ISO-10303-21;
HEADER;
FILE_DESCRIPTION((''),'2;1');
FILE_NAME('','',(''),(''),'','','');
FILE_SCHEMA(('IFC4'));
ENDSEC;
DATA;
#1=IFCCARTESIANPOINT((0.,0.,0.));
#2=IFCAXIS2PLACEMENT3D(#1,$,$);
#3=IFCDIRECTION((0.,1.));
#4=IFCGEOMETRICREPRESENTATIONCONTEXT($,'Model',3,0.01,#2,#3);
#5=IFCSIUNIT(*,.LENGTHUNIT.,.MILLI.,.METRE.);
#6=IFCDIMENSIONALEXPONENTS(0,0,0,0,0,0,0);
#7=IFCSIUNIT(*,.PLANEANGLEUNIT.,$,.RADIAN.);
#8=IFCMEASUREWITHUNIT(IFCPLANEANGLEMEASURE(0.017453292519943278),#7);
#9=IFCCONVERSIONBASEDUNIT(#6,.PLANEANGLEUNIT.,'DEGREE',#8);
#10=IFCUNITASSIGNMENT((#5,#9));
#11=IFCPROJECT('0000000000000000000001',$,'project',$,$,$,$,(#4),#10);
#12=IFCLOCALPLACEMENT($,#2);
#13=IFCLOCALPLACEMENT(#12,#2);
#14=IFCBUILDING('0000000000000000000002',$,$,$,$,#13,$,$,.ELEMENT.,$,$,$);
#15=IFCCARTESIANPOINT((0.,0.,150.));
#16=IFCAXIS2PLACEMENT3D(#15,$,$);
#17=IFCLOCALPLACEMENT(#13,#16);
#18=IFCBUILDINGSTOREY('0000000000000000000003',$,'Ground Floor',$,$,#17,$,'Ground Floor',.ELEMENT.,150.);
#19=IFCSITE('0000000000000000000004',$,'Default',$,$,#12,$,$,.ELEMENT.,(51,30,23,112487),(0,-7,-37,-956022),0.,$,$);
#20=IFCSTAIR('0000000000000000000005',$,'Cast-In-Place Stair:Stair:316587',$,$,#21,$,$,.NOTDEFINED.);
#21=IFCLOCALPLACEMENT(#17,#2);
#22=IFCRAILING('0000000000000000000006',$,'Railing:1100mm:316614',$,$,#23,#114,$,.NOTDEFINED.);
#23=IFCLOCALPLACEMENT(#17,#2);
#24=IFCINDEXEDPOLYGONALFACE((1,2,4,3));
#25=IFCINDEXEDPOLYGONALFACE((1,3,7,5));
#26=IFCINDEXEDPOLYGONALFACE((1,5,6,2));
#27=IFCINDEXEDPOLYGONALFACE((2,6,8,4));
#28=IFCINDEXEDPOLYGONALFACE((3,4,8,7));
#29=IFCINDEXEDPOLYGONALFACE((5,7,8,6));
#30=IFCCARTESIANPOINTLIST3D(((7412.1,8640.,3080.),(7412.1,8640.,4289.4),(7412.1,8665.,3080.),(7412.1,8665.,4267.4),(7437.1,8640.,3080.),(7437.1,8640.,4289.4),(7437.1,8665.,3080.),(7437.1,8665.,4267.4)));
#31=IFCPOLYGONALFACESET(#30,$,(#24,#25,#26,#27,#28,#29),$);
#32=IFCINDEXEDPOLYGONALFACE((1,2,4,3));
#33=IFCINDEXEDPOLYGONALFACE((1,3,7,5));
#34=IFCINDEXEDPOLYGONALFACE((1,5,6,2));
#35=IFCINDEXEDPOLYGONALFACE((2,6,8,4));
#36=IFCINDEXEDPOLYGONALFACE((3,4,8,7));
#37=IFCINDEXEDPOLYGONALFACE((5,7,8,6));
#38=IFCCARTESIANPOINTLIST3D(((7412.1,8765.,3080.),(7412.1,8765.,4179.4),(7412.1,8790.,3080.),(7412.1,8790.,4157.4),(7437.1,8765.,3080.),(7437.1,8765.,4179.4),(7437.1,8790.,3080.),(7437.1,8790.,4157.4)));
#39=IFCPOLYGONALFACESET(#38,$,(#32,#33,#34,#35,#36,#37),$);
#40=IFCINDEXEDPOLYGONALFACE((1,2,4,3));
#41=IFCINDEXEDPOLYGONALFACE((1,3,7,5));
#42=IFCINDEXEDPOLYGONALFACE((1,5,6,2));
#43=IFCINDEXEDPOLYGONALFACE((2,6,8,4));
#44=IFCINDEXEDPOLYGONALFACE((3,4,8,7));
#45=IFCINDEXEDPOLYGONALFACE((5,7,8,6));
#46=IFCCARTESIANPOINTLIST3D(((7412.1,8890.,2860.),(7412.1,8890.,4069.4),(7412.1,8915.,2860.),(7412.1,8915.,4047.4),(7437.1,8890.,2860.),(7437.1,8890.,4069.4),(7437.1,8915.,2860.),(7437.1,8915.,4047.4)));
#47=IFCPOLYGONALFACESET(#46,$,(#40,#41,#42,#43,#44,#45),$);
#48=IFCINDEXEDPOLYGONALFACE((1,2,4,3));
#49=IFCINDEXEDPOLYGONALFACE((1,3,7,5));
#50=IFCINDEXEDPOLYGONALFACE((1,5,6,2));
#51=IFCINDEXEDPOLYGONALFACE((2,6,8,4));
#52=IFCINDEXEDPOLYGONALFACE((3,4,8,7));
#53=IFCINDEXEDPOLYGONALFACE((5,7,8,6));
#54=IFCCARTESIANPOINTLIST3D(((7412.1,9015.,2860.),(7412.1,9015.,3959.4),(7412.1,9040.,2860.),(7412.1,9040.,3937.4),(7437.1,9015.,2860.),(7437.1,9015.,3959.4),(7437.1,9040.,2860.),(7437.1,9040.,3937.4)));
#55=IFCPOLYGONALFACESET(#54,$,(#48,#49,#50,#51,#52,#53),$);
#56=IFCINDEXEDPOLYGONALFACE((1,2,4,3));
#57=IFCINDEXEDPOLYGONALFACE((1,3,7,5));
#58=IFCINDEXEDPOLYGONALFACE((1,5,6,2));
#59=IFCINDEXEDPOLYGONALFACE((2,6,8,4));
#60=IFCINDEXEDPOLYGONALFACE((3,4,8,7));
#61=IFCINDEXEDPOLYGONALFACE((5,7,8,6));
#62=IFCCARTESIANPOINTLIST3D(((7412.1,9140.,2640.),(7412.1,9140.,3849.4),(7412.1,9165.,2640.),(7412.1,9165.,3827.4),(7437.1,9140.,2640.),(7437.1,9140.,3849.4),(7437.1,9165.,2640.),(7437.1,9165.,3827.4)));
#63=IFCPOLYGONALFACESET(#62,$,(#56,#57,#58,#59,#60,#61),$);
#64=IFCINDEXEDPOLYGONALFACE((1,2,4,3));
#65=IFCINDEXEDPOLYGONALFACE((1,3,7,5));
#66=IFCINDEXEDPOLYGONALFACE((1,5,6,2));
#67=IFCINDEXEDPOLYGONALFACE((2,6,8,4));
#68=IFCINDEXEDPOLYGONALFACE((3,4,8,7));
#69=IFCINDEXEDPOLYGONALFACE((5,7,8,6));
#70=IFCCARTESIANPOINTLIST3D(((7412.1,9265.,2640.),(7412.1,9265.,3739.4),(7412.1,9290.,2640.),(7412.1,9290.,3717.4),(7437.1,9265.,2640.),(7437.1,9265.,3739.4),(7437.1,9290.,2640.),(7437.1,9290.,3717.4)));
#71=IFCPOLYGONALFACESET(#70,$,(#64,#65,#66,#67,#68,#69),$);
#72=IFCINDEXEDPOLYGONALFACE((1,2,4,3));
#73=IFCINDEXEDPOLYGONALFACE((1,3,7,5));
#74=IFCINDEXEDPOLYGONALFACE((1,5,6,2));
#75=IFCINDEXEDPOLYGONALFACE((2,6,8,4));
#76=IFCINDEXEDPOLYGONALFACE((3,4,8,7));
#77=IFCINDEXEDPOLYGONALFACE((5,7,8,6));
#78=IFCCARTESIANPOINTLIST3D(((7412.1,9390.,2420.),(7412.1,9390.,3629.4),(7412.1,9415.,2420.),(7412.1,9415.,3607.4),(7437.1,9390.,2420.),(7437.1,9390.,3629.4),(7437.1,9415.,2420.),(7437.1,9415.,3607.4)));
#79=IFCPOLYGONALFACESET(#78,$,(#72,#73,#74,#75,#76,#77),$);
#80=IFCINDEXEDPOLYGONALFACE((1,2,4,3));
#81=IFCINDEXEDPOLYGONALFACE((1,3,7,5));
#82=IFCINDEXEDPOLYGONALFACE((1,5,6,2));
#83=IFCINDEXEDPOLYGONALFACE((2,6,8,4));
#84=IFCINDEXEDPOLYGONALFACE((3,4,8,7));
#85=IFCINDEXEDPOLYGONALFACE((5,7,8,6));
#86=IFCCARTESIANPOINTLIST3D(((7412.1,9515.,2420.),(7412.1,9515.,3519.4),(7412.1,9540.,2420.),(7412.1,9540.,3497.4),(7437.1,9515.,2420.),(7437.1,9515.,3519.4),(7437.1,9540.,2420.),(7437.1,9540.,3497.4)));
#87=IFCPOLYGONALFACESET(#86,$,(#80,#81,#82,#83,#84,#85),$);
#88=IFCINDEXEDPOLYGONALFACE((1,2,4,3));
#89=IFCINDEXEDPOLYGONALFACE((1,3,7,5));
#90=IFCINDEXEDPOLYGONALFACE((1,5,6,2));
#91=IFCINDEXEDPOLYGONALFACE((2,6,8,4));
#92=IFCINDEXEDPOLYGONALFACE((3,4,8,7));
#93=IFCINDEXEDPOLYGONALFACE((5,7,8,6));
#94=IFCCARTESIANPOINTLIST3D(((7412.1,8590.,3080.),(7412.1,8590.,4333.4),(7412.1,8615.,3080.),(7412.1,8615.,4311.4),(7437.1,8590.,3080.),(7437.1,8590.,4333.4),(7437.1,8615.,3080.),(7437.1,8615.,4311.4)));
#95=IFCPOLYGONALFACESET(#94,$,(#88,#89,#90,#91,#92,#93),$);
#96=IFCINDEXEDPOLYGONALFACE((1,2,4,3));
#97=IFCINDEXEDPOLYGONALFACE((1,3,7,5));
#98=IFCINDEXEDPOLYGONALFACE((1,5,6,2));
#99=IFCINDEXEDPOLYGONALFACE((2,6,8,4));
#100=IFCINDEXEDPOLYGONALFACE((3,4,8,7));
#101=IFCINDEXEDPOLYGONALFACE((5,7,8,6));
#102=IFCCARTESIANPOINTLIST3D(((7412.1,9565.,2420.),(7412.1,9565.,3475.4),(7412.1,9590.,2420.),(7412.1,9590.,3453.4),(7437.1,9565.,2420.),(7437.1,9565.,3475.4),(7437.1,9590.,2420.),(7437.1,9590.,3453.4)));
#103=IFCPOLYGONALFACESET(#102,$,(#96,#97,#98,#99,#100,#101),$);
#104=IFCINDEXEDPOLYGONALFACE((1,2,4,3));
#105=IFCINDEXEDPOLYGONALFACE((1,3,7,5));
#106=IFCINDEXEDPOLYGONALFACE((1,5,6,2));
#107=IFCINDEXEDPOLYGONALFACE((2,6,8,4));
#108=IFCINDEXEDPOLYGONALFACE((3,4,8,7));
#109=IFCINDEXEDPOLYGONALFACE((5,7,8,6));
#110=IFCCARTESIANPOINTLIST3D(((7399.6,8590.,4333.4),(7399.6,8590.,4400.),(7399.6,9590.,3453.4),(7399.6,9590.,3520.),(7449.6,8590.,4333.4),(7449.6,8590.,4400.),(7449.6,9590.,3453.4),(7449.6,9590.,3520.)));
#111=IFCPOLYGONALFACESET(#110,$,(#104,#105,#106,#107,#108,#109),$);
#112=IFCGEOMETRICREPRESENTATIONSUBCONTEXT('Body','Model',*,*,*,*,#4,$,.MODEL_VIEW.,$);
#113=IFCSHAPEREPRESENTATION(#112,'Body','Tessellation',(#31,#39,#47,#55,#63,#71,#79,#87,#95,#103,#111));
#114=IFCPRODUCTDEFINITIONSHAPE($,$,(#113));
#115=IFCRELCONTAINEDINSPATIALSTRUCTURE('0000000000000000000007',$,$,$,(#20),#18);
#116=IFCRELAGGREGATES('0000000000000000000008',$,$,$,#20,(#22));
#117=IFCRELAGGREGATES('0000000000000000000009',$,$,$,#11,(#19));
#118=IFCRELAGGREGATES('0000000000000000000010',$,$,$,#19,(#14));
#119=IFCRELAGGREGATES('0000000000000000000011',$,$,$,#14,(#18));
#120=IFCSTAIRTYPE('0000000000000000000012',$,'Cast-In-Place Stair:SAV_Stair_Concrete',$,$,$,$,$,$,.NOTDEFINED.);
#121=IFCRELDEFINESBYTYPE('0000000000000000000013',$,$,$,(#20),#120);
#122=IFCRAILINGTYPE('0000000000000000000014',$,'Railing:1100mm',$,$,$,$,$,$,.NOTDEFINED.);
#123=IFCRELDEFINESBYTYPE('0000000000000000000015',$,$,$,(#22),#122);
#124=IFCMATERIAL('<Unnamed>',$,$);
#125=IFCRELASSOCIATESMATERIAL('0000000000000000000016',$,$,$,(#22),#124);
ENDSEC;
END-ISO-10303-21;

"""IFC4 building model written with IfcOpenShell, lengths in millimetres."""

from ifc_helpers import new_model, entity, si_unit, converted_unit, direction, frame, origin, place, context, subcontext, project, spatial, polyline, outline, extrude, material, type_object, element, aggregate, save


model = new_model("IFC4")

# Units and contexts
model_context = context("Model", 3, precision=0.01, world=origin(), true_north=direction((0.0, 1.0)))
body_context = subcontext(model_context, "Body", "Model", "MODEL_VIEW")
ifc_project = project(units=[si_unit("LENGTHUNIT", "METRE", prefix="MILLI"), converted_unit("PLANEANGLEUNIT", "DEGREE", entity("IfcPlaneAngleMeasure", 0.017453292519943278), si_unit("PLANEANGLEUNIT", "RADIAN"), dimensions=[0, 0, 0, 0, 0, 0, 0])], contexts=[model_context])

# Site, building, storey
site_placement = place(None, origin())
site = spatial("IfcSite", under=ifc_project, at=site_placement, Name="Default", CompositionType="ELEMENT", RefLatitude=(51, 30, 23, 112487), RefLongitude=(0, -7, -37, -956022), RefElevation=0.0)
building_placement = place(site_placement, origin())
building = spatial("IfcBuilding", under=site, at=building_placement, CompositionType="ELEMENT")
storey_placement = place(building_placement, frame((0.0, 0.0, 150.0)))
storey = spatial("IfcBuildingStorey", under=building, at=storey_placement, Name="Ground Floor", LongName="Ground Floor", CompositionType="ELEMENT", Elevation=150.0)

# Shared definitions
ifc_material_1 = material(Name="<Unnamed>")

# Stair, railing
stair_type = type_object("IfcStairType", Name="Cast-In-Place Stair:SAV_Stair_Concrete", PredefinedType="NOTDEFINED")
stair_placement = place(storey_placement, origin())
stair = element("IfcStair", 1, at=stair_placement, inside=storey, type_object=stair_type, Name="Cast-In-Place Stair:Stair:316587", PredefinedType="NOTDEFINED")
railing_type_1 = type_object("IfcRailingType", Name="Railing:1100mm", PredefinedType="NOTDEFINED")
railing_1_placement = place(stair_placement, frame((7399.6, 8590.0, 2420.0)))
railing_1 = element("IfcRailing", 2, at=railing_1_placement, type_object=railing_type_1, material=ifc_material_1, Name="Railing:1100mm:316614", PredefinedType="NOTDEFINED", context=body_context, shape_type="SweptSolid", body=[
    extrude(outline(polyline([(-599.2, -12.5), (588.2, -12.5), (610.2, 12.5), (-599.2, 12.5), (-599.2, -12.5)])), frame((12.5, 62.5, 1259.2), z_axis=(1.0, 0.0, 0.0), x_axis=(0.0, 0.0, 1.0)), (0.0, 0.0, 1.0), 25.0),
    extrude(outline(polyline([(-544.2, -12.5), (533.2, -12.5), (555.2, 12.5), (-544.2, 12.5), (-544.2, -12.5)])), frame((12.5, 187.5, 1204.2), z_axis=(1.0, 0.0, 0.0), x_axis=(0.0, 0.0, 1.0)), (0.0, 0.0, 1.0), 25.0),
    extrude(outline(polyline([(-599.2, -12.5), (588.2, -12.5), (610.2, 12.5), (-599.2, 12.5), (-599.2, -12.5)])), frame((12.5, 312.5, 1039.2), z_axis=(1.0, 0.0, 0.0), x_axis=(0.0, 0.0, 1.0)), (0.0, 0.0, 1.0), 25.0),
    extrude(outline(polyline([(-544.2, -12.5), (533.2, -12.5), (555.2, 12.5), (-544.2, 12.5), (-544.2, -12.5)])), frame((12.5, 437.5, 984.2), z_axis=(1.0, 0.0, 0.0), x_axis=(0.0, 0.0, 1.0)), (0.0, 0.0, 1.0), 25.0),
    extrude(outline(polyline([(-599.2, -12.5), (588.2, -12.5), (610.2, 12.5), (-599.2, 12.5), (-599.2, -12.5)])), frame((12.5, 562.5, 819.2), z_axis=(1.0, 0.0, 0.0), x_axis=(0.0, 0.0, 1.0)), (0.0, 0.0, 1.0), 25.0),
    extrude(outline(polyline([(-544.2, -12.5), (533.2, -12.5), (555.2, 12.5), (-544.2, 12.5), (-544.2, -12.5)])), frame((12.5, 687.5, 764.2), z_axis=(1.0, 0.0, 0.0), x_axis=(0.0, 0.0, 1.0)), (0.0, 0.0, 1.0), 25.0),
    extrude(outline(polyline([(-599.2, -12.5), (588.2, -12.5), (610.2, 12.5), (-599.2, 12.5), (-599.2, -12.5)])), frame((12.5, 812.5, 599.2), z_axis=(1.0, 0.0, 0.0), x_axis=(0.0, 0.0, 1.0)), (0.0, 0.0, 1.0), 25.0),
    extrude(outline(polyline([(-544.2, -12.5), (533.2, -12.5), (555.2, 12.5), (-544.2, 12.5), (-544.2, -12.5)])), frame((12.5, 937.5, 544.2), z_axis=(1.0, 0.0, 0.0), x_axis=(0.0, 0.0, 1.0)), (0.0, 0.0, 1.0), 25.0),
    extrude(outline(polyline([(-621.2, -12.5), (610.2, -12.5), (632.2, 12.5), (-621.2, 12.5), (-621.2, -12.5)])), frame((12.5, 12.5, 1281.2), z_axis=(1.0, 0.0, 0.0), x_axis=(0.0, 0.0, 1.0)), (0.0, 0.0, 1.0), 25.0),
    extrude(outline(polyline([(-522.2, -12.5), (511.2, -12.5), (533.2, 12.5), (-522.2, 12.5), (-522.2, -12.5)])), frame((12.5, 987.5, 522.2), z_axis=(1.0, 0.0, 0.0), x_axis=(0.0, 0.0, 1.0)), (0.0, 0.0, 1.0), 25.0),
    extrude(outline(polyline([(-644.0, -25.0), (688.0, -25.0), (644.0, 25.0), (-688.0, 25.0), (-644.0, -25.0)])), frame((0.0, 500.0, 1506.7), z_axis=(1.0, 0.0, 0.0), x_axis=(0.0, -0.750714, 0.660628)), (0.0, 0.0, 1.0), 50.0),
])
aggregate(stair, [railing_1])

save(model, "model.ifc")
